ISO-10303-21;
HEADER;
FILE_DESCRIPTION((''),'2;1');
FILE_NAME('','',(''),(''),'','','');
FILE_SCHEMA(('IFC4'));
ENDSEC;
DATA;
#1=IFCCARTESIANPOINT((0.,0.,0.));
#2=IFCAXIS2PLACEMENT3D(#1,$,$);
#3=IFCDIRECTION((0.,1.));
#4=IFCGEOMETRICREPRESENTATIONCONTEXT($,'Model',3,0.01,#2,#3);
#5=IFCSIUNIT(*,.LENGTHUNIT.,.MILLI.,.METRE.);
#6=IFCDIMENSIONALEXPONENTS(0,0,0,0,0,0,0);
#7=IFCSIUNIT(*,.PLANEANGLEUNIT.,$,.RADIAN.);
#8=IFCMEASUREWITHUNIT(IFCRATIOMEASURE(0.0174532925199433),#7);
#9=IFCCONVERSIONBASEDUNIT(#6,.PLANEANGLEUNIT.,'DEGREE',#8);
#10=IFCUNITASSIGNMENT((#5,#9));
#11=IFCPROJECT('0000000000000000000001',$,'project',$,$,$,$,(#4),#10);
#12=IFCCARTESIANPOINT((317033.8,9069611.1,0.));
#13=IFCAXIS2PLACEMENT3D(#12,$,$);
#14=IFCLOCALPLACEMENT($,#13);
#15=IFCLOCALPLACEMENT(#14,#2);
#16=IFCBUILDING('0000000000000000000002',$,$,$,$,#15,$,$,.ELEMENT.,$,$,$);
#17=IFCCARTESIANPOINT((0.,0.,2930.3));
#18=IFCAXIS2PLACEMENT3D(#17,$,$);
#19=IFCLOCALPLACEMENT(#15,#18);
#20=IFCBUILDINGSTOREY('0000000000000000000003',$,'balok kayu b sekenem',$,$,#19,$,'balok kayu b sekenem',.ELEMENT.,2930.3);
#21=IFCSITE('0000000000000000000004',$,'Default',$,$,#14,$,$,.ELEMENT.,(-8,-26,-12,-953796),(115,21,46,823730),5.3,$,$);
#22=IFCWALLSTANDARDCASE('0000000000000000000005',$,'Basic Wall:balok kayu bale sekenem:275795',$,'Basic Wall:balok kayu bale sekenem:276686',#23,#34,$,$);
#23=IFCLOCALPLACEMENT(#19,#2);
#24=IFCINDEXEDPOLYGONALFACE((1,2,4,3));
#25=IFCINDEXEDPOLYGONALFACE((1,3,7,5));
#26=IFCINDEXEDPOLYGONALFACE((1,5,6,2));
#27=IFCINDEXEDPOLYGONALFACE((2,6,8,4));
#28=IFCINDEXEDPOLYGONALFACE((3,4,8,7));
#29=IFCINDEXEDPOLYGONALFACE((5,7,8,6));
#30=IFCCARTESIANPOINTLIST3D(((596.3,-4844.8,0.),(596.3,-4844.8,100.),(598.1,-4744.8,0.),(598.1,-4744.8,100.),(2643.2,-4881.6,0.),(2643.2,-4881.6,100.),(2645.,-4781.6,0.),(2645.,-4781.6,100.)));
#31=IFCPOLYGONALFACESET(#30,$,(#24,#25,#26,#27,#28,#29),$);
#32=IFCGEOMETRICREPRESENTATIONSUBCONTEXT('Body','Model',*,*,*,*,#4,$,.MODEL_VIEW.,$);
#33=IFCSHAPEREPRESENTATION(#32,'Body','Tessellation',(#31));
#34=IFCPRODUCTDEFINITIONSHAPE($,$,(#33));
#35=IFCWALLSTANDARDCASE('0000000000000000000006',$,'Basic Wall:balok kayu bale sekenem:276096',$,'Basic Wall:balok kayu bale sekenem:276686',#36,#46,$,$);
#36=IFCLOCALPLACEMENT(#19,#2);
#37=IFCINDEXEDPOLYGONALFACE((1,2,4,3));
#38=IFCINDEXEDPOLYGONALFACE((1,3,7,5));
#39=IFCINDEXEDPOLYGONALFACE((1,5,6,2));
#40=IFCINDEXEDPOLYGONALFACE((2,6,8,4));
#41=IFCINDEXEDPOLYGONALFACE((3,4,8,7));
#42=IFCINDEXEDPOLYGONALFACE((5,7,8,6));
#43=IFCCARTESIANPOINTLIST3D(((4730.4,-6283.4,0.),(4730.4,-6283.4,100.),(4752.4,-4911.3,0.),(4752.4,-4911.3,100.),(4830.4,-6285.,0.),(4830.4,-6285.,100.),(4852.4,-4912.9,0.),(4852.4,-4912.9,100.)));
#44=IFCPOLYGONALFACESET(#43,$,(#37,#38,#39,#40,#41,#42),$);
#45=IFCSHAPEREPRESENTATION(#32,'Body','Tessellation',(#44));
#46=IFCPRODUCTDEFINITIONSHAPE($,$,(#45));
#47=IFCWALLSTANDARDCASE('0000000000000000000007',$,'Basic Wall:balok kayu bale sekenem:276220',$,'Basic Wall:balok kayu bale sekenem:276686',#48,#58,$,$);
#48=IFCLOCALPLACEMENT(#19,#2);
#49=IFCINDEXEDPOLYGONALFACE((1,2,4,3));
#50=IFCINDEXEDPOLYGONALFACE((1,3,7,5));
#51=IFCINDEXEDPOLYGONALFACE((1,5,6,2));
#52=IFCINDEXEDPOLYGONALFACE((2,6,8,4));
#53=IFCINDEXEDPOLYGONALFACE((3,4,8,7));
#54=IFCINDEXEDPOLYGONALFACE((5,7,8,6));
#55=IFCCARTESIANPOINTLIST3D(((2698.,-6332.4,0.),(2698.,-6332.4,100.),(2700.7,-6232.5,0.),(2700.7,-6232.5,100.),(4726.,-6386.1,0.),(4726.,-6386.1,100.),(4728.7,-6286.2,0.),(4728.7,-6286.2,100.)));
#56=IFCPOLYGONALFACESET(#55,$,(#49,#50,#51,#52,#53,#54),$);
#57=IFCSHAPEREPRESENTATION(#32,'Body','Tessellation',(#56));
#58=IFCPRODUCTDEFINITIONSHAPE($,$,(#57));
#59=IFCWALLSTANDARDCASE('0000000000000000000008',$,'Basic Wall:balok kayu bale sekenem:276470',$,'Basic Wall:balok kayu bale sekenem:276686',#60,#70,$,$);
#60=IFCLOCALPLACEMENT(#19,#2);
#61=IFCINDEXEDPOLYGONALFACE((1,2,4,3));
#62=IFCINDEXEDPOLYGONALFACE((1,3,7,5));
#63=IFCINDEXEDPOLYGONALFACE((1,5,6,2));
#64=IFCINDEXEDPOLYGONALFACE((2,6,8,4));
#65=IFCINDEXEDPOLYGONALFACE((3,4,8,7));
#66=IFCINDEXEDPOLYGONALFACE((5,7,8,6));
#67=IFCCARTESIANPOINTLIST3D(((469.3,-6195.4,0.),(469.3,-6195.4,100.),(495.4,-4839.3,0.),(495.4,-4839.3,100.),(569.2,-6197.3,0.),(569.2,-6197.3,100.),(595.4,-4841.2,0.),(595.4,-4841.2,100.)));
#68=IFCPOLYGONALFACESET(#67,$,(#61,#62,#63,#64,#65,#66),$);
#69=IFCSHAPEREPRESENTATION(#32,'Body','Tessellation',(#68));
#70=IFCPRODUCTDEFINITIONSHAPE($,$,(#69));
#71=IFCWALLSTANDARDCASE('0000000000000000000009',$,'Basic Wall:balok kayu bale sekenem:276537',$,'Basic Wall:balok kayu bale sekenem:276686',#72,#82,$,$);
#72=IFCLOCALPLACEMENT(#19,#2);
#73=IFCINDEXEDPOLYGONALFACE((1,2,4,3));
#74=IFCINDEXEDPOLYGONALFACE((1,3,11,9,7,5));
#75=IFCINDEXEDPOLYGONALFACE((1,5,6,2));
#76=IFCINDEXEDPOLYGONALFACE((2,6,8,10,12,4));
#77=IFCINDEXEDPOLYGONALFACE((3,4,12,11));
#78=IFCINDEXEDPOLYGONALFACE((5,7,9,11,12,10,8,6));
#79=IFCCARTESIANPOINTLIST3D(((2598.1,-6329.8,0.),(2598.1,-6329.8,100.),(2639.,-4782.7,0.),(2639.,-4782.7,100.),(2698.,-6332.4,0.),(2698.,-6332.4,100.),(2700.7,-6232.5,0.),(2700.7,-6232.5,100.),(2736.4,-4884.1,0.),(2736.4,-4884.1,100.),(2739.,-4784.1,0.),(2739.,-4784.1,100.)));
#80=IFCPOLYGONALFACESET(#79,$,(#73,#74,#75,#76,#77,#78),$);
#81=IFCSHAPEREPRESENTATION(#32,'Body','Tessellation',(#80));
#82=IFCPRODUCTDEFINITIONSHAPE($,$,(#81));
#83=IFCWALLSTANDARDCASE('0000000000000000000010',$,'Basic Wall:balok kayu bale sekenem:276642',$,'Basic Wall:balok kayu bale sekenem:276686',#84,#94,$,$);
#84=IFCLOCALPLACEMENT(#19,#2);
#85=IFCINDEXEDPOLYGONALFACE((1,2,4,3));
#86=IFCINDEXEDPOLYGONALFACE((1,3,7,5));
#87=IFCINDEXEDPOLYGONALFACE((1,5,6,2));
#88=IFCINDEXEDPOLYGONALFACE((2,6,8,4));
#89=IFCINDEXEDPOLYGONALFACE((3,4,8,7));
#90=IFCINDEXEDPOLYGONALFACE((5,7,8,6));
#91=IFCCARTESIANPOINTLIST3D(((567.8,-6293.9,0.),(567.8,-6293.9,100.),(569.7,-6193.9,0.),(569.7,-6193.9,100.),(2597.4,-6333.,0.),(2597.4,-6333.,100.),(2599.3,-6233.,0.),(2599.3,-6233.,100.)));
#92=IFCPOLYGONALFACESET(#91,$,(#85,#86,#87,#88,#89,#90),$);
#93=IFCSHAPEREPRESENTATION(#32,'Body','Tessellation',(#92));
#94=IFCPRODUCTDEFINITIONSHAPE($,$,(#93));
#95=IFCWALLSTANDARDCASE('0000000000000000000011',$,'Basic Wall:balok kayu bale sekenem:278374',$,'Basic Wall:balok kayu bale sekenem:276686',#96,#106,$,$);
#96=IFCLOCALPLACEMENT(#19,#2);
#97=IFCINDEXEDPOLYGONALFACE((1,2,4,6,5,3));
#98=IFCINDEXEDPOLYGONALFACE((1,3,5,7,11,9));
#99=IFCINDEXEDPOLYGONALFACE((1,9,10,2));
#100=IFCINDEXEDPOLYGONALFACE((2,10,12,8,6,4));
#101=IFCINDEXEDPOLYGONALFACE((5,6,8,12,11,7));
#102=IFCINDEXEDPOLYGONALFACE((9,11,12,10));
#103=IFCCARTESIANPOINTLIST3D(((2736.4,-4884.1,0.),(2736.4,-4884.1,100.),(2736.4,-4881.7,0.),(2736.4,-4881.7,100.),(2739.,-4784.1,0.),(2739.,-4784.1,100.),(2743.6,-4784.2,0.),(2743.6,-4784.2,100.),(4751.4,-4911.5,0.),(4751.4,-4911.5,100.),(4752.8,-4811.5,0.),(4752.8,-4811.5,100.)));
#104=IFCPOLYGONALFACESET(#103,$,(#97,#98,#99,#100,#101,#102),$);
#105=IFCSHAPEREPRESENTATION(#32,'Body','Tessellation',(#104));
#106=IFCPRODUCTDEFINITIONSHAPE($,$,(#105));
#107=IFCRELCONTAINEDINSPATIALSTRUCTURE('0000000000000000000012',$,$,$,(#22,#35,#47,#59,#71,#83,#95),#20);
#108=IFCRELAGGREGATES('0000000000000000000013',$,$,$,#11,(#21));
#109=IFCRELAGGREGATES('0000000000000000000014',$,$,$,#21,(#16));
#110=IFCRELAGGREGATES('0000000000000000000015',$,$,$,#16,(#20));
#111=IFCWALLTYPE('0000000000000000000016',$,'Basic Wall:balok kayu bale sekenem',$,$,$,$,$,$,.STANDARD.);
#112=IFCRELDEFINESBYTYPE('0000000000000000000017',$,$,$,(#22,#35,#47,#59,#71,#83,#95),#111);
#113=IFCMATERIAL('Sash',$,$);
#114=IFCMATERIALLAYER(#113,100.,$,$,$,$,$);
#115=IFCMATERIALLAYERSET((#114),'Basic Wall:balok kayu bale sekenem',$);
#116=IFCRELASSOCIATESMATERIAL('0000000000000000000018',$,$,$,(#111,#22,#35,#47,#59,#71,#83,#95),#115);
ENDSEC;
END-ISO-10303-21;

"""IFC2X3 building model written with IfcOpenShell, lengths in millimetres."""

from ifc_helpers import new_model, entity, si_unit, converted_unit, direction, frame, frame_2d, origin, place, context, subcontext, project, spatial, polyline, rectangle, outline, extrude, material, layer, layer_set, layer_usage, type_object, element, save


model = new_model("IFC2X3")

# Units and contexts
model_context = context("Model", 3, precision=0.01, world=origin(), true_north=direction((0.0, 1.0)))
body_context = subcontext(model_context, "Body", "Model", "MODEL_VIEW")
ifc_project = project(units=[si_unit("LENGTHUNIT", "METRE", prefix="MILLI"), converted_unit("PLANEANGLEUNIT", "DEGREE", entity("IfcRatioMeasure", 0.0174532925199433), si_unit("PLANEANGLEUNIT", "RADIAN"), dimensions=[0, 0, 0, 0, 0, 0, 0])], contexts=[model_context])

# Site, building, storey
site_placement = place(None, frame((317033.8, 9069611.1, 0.0)))
site = spatial("IfcSite", under=ifc_project, at=site_placement, Name="Default", CompositionType="ELEMENT", RefLatitude=(-8, -26, -12, -953796), RefLongitude=(115, 21, 46, 823730), RefElevation=5.3)
building_placement = place(site_placement, origin())
building = spatial("IfcBuilding", under=site, at=building_placement, CompositionType="ELEMENT")
storey_placement = place(building_placement, frame((0.0, 0.0, 2930.3)))
storey = spatial("IfcBuildingStorey", under=building, at=storey_placement, Name="balok kayu b sekenem", LongName="balok kayu b sekenem", CompositionType="ELEMENT", Elevation=2930.3)

# Walls
ifc_material = material(Name="Sash")
ifc_layer = layer(ifc_material, 100.0)
ifc_layer_set = layer_set([ifc_layer], Name="Basic Wall:balok kayu bale sekenem")
ifc_layer_usage_1 = layer_usage(ifc_layer_set, "AXIS2", "NEGATIVE", 50.0)
wall_type = type_object("IfcWallType", Name="Basic Wall:balok kayu bale sekenem", PredefinedType="STANDARD", material=ifc_layer_set)
wall_1_placement = place(storey_placement, frame((597.2, -4794.8, 0.0), z_axis=(0.0, 0.0, 1.0), x_axis=(0.999839, -0.017947, 0.0)))
element("IfcWallStandardCase", 1, at=wall_1_placement, inside=storey, type_object=wall_type, material=ifc_layer_usage_1, Name="Basic Wall:balok kayu bale sekenem:275795", ObjectType="Basic Wall:balok kayu bale sekenem:276686", context=body_context, shape_type="SweptSolid", body=[
    extrude(rectangle(XDim=2047.2, YDim=100.0, at=frame_2d((1023.6, 0.0), x_axis=(-1.0, 0.0))), origin(), (0.0, 0.0, 1.0), 100.0),
])
ifc_layer_usage_2 = layer_usage(ifc_layer_set, "AXIS2", "NEGATIVE", 50.0)
wall_2_placement = place(storey_placement, frame((4802.4, -4912.1, 0.0), z_axis=(0.0, 0.0, 1.0), x_axis=(-0.016027, -0.999872, 0.0)))
element("IfcWallStandardCase", 2, at=wall_2_placement, inside=storey, type_object=wall_type, material=ifc_layer_usage_2, Name="Basic Wall:balok kayu bale sekenem:276096", ObjectType="Basic Wall:balok kayu bale sekenem:276686", context=body_context, shape_type="SweptSolid", body=[
    extrude(rectangle(XDim=1372.3, YDim=100.0, at=frame_2d((686.2, 0.0), x_axis=(-1.0, 0.0))), origin(), (0.0, 0.0, 1.0), 100.0),
])
ifc_layer_usage_3 = layer_usage(ifc_layer_set, "AXIS2", "NEGATIVE", 50.0)
wall_3_placement = place(storey_placement, frame((4727.4, -6336.1, 0.0), z_axis=(0.0, 0.0, 1.0), x_axis=(-0.99965, 0.026463, 0.0)))
element("IfcWallStandardCase", 3, at=wall_3_placement, inside=storey, type_object=wall_type, material=ifc_layer_usage_3, Name="Basic Wall:balok kayu bale sekenem:276220", ObjectType="Basic Wall:balok kayu bale sekenem:276686", context=body_context, shape_type="SweptSolid", body=[
    extrude(rectangle(XDim=2028.7, YDim=100.0, at=frame_2d((1014.4, 0.0), x_axis=(-1.0, 0.0))), origin(), (0.0, 0.0, 1.0), 100.0),
])
ifc_layer_usage_4 = layer_usage(ifc_layer_set, "AXIS2", "NEGATIVE", 50.0)
wall_4_placement = place(storey_placement, frame((519.3, -6196.4, 0.0), z_axis=(0.0, 0.0, 1.0), x_axis=(0.019244, 0.999815, 0.0)))
element("IfcWallStandardCase", 4, at=wall_4_placement, inside=storey, type_object=wall_type, material=ifc_layer_usage_4, Name="Basic Wall:balok kayu bale sekenem:276470", ObjectType="Basic Wall:balok kayu bale sekenem:276686", context=body_context, shape_type="SweptSolid", body=[
    extrude(rectangle(XDim=1356.4, YDim=100.0, at=frame_2d((678.2, 0.0), x_axis=(-1.0, 0.0))), origin(), (0.0, 0.0, 1.0), 100.0),
])
ifc_layer_usage_5 = layer_usage(ifc_layer_set, "AXIS2", "NEGATIVE", 50.0)
wall_5_placement = place(storey_placement, frame((2648.1, -6331.1, 0.0), z_axis=(0.0, 0.0, 1.0), x_axis=(0.026463, 0.99965, 0.0)))
element("IfcWallStandardCase", 5, at=wall_5_placement, inside=storey, type_object=wall_type, material=ifc_layer_usage_5, Name="Basic Wall:balok kayu bale sekenem:276537", ObjectType="Basic Wall:balok kayu bale sekenem:276686", context=body_context, shape_type="SweptSolid", body=[
    extrude(outline(polyline([(1548.9, -50.0), (1547.6, 50.0), (0.0, 50.0), (0.0, -50.0), (100.0, -50.0), (1448.9, -50.0), (1548.9, -50.0)])), origin(), (0.0, 0.0, 1.0), 100.0),
])
ifc_layer_usage_6 = layer_usage(ifc_layer_set, "AXIS2", "NEGATIVE", 50.0)
wall_6_placement = place(storey_placement, frame((2598.4, -6283.0, 0.0), z_axis=(0.0, 0.0, 1.0), x_axis=(-0.999815, 0.019244, 0.0)))
element("IfcWallStandardCase", 6, at=wall_6_placement, inside=storey, type_object=wall_type, material=ifc_layer_usage_6, Name="Basic Wall:balok kayu bale sekenem:276642", ObjectType="Basic Wall:balok kayu bale sekenem:276686", context=body_context, shape_type="SweptSolid", body=[
    extrude(rectangle(XDim=2030.0, YDim=100.0, at=frame_2d((1015.0, 0.0), x_axis=(-1.0, 0.0))), origin(), (0.0, 0.0, 1.0), 100.0),
])
ifc_layer_usage_7 = layer_usage(ifc_layer_set, "AXIS2", "NEGATIVE", 50.0)
wall_7_placement = place(storey_placement, frame((2737.1, -4834.1, 0.0), z_axis=(0.0, 0.0, 1.0), x_axis=(0.999907, -0.013611, 0.0)))
element("IfcWallStandardCase", 7, at=wall_7_placement, inside=storey, type_object=wall_type, material=ifc_layer_usage_7, Name="Basic Wall:balok kayu bale sekenem:278374", ObjectType="Basic Wall:balok kayu bale sekenem:276686", context=body_context, shape_type="SweptSolid", body=[
    extrude(outline(polyline([(2015.2, -50.0), (2015.2, 50.0), (5.9, 50.0), (1.3, 50.0), (0.0, -47.6), (0.0, -50.0), (2015.2, -50.0)])), origin(), (0.0, 0.0, 1.0), 100.0),
])

save(model, "model.ifc")
